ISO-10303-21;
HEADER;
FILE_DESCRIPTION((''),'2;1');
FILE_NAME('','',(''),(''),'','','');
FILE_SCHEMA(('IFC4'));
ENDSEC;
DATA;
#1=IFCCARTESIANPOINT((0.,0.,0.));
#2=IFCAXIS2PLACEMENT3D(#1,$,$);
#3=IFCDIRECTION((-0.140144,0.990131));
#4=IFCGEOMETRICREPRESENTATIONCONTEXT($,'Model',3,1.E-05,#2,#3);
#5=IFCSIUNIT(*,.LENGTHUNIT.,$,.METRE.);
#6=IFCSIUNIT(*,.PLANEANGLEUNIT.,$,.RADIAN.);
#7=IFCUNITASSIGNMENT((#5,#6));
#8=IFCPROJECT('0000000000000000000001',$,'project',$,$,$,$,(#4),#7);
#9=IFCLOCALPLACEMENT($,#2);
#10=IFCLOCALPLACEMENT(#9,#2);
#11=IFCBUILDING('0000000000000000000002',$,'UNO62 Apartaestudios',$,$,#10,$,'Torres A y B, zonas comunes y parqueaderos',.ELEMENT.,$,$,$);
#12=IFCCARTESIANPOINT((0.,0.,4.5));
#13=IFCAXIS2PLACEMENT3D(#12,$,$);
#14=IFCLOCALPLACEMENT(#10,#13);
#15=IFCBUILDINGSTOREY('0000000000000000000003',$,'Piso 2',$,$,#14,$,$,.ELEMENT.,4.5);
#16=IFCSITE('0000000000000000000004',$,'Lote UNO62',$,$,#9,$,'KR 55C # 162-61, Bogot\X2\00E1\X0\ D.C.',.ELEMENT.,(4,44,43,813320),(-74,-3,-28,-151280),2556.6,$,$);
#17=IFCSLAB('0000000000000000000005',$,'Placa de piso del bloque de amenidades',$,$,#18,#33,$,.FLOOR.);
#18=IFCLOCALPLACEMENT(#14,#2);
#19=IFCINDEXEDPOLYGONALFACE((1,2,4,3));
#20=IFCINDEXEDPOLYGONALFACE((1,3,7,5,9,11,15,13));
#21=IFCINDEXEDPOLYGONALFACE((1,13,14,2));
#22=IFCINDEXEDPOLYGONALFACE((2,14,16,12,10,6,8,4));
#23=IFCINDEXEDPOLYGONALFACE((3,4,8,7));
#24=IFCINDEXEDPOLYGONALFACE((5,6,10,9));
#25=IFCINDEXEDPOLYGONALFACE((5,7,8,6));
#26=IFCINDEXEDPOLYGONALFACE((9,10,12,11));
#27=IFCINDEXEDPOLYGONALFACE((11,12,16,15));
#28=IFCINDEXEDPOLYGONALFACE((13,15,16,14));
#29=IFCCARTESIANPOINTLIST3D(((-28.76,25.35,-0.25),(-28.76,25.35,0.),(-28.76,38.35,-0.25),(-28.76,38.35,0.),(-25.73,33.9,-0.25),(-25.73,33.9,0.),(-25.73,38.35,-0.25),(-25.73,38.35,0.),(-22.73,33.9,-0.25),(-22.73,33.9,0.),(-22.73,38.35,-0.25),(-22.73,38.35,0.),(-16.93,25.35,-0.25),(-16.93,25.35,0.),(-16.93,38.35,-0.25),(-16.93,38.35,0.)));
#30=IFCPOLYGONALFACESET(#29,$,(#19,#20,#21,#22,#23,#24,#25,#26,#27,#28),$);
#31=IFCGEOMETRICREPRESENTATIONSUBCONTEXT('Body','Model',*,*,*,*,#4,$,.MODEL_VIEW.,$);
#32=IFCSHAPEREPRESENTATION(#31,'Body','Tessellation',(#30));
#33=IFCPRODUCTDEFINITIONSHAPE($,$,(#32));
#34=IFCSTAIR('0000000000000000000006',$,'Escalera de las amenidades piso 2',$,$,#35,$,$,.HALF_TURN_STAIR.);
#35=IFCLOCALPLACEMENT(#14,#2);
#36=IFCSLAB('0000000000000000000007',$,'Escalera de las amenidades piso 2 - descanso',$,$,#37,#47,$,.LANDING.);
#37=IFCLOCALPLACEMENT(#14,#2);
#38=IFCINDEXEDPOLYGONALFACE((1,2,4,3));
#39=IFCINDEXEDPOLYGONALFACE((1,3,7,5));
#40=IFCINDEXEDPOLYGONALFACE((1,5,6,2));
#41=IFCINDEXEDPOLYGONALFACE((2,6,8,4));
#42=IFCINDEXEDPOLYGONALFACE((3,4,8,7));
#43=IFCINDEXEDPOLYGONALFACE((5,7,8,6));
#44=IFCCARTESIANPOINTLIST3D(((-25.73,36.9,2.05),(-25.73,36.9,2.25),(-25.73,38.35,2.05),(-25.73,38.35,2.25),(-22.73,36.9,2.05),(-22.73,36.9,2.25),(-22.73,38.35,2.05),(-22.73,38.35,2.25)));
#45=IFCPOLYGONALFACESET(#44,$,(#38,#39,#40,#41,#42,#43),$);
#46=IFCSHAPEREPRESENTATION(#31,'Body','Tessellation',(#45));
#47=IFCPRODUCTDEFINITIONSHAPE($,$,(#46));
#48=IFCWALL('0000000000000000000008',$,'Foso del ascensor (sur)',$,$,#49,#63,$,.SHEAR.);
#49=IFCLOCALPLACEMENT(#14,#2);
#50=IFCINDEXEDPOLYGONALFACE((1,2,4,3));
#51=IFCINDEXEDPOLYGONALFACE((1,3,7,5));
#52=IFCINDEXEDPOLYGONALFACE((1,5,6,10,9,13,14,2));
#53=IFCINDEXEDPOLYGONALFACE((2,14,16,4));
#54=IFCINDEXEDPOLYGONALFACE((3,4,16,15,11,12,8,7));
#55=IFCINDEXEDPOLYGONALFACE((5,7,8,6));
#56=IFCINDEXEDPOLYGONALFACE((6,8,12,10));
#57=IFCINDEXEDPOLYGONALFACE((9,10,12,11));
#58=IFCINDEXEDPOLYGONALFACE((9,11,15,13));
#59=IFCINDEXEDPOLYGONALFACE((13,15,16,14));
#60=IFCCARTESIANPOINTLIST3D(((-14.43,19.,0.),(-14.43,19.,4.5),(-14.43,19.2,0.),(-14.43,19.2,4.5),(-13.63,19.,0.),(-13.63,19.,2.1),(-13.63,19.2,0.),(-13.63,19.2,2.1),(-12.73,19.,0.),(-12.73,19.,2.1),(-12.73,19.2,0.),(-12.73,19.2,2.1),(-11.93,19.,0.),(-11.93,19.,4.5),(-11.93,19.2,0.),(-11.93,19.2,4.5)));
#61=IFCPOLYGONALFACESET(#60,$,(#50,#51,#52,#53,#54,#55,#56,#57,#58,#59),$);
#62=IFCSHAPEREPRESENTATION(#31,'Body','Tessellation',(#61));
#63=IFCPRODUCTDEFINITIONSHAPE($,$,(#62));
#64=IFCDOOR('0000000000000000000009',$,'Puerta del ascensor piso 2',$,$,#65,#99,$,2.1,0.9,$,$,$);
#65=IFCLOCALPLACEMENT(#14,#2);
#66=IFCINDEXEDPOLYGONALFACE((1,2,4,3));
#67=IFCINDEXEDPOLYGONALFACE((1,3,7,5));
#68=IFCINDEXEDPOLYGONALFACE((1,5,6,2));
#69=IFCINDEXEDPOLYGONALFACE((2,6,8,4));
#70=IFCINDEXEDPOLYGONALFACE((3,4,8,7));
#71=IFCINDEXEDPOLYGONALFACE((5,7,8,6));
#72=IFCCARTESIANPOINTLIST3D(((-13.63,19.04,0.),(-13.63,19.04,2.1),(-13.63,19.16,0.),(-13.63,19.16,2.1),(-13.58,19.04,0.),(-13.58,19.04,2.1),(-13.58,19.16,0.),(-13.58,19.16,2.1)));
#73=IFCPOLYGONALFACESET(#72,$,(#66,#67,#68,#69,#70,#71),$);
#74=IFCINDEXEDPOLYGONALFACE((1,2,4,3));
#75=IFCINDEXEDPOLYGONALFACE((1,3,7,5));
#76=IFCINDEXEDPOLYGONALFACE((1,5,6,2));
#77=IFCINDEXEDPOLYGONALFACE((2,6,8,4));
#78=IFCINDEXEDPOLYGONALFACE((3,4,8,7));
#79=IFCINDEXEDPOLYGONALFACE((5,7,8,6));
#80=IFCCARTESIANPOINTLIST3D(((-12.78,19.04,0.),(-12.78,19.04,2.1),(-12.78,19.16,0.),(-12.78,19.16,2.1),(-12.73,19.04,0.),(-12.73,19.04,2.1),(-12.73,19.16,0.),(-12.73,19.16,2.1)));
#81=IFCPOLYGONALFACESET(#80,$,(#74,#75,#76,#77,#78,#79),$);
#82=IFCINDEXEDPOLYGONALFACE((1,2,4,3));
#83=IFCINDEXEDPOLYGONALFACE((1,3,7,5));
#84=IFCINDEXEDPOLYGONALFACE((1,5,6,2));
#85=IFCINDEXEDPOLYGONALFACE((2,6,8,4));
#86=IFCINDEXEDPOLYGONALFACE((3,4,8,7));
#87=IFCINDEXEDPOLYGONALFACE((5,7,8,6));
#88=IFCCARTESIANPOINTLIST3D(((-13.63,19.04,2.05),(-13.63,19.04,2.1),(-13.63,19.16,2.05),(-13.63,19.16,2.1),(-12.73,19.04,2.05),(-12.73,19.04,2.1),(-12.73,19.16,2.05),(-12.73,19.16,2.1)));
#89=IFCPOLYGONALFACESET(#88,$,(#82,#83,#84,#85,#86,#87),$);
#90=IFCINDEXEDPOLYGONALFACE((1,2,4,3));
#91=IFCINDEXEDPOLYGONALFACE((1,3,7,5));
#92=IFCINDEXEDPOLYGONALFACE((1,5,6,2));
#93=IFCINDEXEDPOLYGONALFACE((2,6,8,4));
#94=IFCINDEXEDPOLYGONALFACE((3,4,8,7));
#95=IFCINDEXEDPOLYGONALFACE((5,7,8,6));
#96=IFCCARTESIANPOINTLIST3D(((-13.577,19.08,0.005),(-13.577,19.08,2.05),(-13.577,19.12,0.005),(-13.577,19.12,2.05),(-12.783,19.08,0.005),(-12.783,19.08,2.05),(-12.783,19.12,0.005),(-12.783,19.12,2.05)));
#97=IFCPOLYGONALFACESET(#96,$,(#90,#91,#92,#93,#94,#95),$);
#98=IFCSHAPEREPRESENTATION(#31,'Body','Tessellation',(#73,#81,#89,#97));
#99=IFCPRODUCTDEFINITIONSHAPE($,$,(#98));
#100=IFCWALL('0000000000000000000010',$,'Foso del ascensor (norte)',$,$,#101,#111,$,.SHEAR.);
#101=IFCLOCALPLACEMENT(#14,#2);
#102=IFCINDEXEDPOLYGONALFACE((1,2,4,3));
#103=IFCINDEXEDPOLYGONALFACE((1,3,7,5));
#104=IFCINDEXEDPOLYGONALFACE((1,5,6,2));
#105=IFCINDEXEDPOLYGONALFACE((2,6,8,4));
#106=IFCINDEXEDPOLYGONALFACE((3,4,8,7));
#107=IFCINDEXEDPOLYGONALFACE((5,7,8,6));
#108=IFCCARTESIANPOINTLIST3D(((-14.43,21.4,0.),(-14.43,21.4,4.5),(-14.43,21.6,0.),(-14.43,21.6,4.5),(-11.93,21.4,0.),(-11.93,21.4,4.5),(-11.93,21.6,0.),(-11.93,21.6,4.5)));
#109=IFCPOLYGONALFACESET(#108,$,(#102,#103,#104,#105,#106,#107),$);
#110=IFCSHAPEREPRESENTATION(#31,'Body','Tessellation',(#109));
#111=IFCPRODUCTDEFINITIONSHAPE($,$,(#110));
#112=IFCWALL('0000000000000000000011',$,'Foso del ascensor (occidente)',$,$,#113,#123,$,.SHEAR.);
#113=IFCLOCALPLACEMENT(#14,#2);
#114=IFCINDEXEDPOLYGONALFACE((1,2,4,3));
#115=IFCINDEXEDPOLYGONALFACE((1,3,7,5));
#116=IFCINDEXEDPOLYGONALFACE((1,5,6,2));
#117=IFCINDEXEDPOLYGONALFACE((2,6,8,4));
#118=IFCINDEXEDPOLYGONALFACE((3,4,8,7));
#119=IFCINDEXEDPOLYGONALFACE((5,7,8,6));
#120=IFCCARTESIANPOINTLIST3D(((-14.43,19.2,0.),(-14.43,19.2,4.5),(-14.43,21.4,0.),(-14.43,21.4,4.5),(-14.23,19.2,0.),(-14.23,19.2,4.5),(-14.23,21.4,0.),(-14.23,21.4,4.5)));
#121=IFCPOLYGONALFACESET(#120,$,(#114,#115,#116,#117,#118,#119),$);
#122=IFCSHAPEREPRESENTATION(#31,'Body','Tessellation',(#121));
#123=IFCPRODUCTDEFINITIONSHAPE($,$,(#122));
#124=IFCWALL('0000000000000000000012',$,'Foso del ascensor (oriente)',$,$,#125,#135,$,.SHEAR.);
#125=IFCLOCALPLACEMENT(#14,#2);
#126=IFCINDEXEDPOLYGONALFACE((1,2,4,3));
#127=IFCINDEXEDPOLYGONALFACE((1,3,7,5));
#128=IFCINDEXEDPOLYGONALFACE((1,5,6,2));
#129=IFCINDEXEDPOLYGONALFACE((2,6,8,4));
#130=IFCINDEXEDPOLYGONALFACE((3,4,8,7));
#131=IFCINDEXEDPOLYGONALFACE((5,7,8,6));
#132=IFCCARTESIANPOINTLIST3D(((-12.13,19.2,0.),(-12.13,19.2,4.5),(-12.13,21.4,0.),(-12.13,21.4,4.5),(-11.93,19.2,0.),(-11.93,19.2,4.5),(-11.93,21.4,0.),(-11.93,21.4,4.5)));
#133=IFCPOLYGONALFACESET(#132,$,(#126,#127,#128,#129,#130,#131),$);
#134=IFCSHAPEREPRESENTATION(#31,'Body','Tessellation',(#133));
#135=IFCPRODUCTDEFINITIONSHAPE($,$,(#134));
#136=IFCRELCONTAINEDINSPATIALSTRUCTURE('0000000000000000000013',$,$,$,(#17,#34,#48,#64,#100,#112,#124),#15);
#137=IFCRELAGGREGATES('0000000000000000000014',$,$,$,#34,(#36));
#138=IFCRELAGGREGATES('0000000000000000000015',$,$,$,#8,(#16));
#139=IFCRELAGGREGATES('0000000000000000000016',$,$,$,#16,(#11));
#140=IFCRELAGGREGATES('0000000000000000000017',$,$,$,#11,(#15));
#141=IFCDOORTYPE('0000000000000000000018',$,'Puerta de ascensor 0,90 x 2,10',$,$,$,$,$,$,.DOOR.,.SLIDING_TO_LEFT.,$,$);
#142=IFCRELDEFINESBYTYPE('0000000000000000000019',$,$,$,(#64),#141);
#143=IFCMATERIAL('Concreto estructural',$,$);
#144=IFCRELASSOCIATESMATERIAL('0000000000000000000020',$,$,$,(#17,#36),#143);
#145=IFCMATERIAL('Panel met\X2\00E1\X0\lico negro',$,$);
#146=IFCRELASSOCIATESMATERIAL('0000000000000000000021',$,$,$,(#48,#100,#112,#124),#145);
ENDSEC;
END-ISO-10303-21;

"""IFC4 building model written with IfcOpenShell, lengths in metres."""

from ifc_helpers import new_model, si_unit, direction, frame, frame_2d, origin, place, context, subcontext, project, spatial, rectangle, extrude, source, transform, mapped, material, type_object, type_shapes, element, fill, aggregate, save


model = new_model("IFC4")

# Units and contexts
model_context = context("Model", 3, precision=1e-05, world=origin(), true_north=direction((-0.140144, 0.990131)))
body_context = subcontext(model_context, "Body", "Model", "MODEL_VIEW")
ifc_project = project(units=[si_unit("LENGTHUNIT", "METRE"), si_unit("PLANEANGLEUNIT", "RADIAN")], contexts=[model_context])

# Site, building, storey
site_placement = place(None, origin())
site = spatial("IfcSite", under=ifc_project, at=site_placement, Name="Lote UNO62", LongName="KR 55C # 162-61, Bogotá D.C.", CompositionType="ELEMENT", RefLatitude=(4, 44, 43, 813320), RefLongitude=(-74, -3, -28, -151280), RefElevation=2556.6)
building_placement = place(site_placement, origin())
building = spatial("IfcBuilding", under=site, at=building_placement, Name="UNO62 Apartaestudios", LongName="Torres A y B, zonas comunes y parqueaderos", CompositionType="ELEMENT")
storey_placement = place(building_placement, frame((0.0, 0.0, 4.5)))
storey = spatial("IfcBuildingStorey", under=building, at=storey_placement, Name="Piso 2", CompositionType="ELEMENT", Elevation=4.5)

# Slab, opening
ifc_material_1 = material(Name="Concreto estructural")
slab_1_placement = place(storey_placement, origin())
slab_1 = element("IfcSlab", 1, at=slab_1_placement, inside=storey, material=ifc_material_1, Name="Placa de piso del bloque de amenidades", PredefinedType="FLOOR", context=body_context, shape_type="SweptSolid", body=[
    extrude(rectangle(XDim=11.83, YDim=13.0, at=frame_2d((-22.845, 31.85))), frame((0.0, 0.0, -0.25)), (0.0, 0.0, 1.0), 0.25),
])
opening_1_placement = place(slab_1_placement, origin())
element("IfcOpeningElement", 2, at=opening_1_placement, cuts=slab_1, PredefinedType="OPENING", context=body_context, shape_type="SweptSolid", body=[
    extrude(rectangle(XDim=3.0, YDim=4.45, at=frame_2d((-24.23, 36.125))), frame((0.0, 0.0, -0.3)), (0.0, 0.0, 1.0), 0.35),
])

# Stair, slab
stair_placement = place(storey_placement, origin())
stair = element("IfcStair", 3, at=stair_placement, inside=storey, Name="Escalera de las amenidades piso 2", PredefinedType="HALF_TURN_STAIR")
slab_2_placement = place(storey_placement, origin())
slab_2 = element("IfcSlab", 4, at=slab_2_placement, material=ifc_material_1, Name="Escalera de las amenidades piso 2 - descanso", PredefinedType="LANDING", context=body_context, shape_type="SweptSolid", body=[
    extrude(rectangle(XDim=3.0, YDim=1.45, at=frame_2d((-24.23, 37.625))), frame((0.0, 0.0, 2.05)), (0.0, 0.0, 1.0), 0.2),
])

# Wall, opening, door
ifc_material_2 = material(Name="Panel metálico negro")
wall_1_placement = place(storey_placement, origin())
wall_1 = element("IfcWall", 5, at=wall_1_placement, inside=storey, material=ifc_material_2, Name="Foso del ascensor (sur)", PredefinedType="SHEAR", context=body_context, shape_type="SweptSolid", body=[
    extrude(rectangle(XDim=2.5, YDim=0.2, at=frame_2d((-13.18, 19.1))), origin(), (0.0, 0.0, 1.0), 4.5),
])
opening_2_placement = place(wall_1_placement, origin())
opening_2 = element("IfcOpeningElement", 6, at=opening_2_placement, cuts=wall_1, PredefinedType="OPENING", context=body_context, shape_type="SweptSolid", body=[
    extrude(rectangle(XDim=0.9, YDim=0.3, at=frame_2d((-13.18, 19.1))), origin(), (0.0, 0.0, 1.0), 2.1),
])
door_type_1 = type_object("IfcDoorType", Name="Puerta de ascensor 0,90 x 2,10", OperationType="SLIDING_TO_LEFT", PredefinedType="DOOR")
shared_shape_1 = source(origin(), body_context, "Body", "SweptSolid", [
    extrude(rectangle(XDim=0.05, YDim=0.12, at=frame_2d((0.025, 0.0))), origin(), (0.0, 0.0, 1.0), 2.1),
    extrude(rectangle(XDim=0.05, YDim=0.12, at=frame_2d((0.875, 0.0))), origin(), (0.0, 0.0, 1.0), 2.1),
    extrude(rectangle(XDim=0.9, YDim=0.12, at=frame_2d((0.45, 0.0))), frame((0.0, 0.0, 2.05)), (0.0, 0.0, 1.0), 0.05),
    extrude(rectangle(XDim=0.794, YDim=0.04, at=frame_2d((0.45, 0.0))), frame((0.0, 0.0, 0.005)), (0.0, 0.0, 1.0), 2.045),
])
type_shapes(door_type_1, [shared_shape_1])
door_1_placement = place(storey_placement, frame((-13.63, 19.1, 0.0), z_axis=(0.0, 0.0, 1.0), x_axis=(1.0, 0.0, 0.0)))
door_1 = element("IfcDoor", 7, at=door_1_placement, inside=storey, type_object=door_type_1, Name="Puerta del ascensor piso 2", OverallHeight=2.1, OverallWidth=0.9, context=body_context, shape_type="MappedRepresentation", body=[
    mapped(shared_shape_1, transform((0.0, 0.0, 0.0))),
])
fill(opening_2, door_1)

# Walls
wall_2_placement = place(storey_placement, origin())
element("IfcWall", 8, at=wall_2_placement, inside=storey, material=ifc_material_2, Name="Foso del ascensor (norte)", PredefinedType="SHEAR", context=body_context, shape_type="SweptSolid", body=[
    extrude(rectangle(XDim=2.5, YDim=0.2, at=frame_2d((-13.18, 21.5))), origin(), (0.0, 0.0, 1.0), 4.5),
])
wall_3_placement = place(storey_placement, origin())
element("IfcWall", 9, at=wall_3_placement, inside=storey, material=ifc_material_2, Name="Foso del ascensor (occidente)", PredefinedType="SHEAR", context=body_context, shape_type="SweptSolid", body=[
    extrude(rectangle(XDim=0.2, YDim=2.2, at=frame_2d((-14.33, 20.3))), origin(), (0.0, 0.0, 1.0), 4.5),
])
wall_4_placement = place(storey_placement, origin())
element("IfcWall", 10, at=wall_4_placement, inside=storey, material=ifc_material_2, Name="Foso del ascensor (oriente)", PredefinedType="SHEAR", context=body_context, shape_type="SweptSolid", body=[
    extrude(rectangle(XDim=0.2, YDim=2.2, at=frame_2d((-12.03, 20.3))), origin(), (0.0, 0.0, 1.0), 4.5),
])

aggregate(stair, [slab_2])

save(model, "model.ifc")
